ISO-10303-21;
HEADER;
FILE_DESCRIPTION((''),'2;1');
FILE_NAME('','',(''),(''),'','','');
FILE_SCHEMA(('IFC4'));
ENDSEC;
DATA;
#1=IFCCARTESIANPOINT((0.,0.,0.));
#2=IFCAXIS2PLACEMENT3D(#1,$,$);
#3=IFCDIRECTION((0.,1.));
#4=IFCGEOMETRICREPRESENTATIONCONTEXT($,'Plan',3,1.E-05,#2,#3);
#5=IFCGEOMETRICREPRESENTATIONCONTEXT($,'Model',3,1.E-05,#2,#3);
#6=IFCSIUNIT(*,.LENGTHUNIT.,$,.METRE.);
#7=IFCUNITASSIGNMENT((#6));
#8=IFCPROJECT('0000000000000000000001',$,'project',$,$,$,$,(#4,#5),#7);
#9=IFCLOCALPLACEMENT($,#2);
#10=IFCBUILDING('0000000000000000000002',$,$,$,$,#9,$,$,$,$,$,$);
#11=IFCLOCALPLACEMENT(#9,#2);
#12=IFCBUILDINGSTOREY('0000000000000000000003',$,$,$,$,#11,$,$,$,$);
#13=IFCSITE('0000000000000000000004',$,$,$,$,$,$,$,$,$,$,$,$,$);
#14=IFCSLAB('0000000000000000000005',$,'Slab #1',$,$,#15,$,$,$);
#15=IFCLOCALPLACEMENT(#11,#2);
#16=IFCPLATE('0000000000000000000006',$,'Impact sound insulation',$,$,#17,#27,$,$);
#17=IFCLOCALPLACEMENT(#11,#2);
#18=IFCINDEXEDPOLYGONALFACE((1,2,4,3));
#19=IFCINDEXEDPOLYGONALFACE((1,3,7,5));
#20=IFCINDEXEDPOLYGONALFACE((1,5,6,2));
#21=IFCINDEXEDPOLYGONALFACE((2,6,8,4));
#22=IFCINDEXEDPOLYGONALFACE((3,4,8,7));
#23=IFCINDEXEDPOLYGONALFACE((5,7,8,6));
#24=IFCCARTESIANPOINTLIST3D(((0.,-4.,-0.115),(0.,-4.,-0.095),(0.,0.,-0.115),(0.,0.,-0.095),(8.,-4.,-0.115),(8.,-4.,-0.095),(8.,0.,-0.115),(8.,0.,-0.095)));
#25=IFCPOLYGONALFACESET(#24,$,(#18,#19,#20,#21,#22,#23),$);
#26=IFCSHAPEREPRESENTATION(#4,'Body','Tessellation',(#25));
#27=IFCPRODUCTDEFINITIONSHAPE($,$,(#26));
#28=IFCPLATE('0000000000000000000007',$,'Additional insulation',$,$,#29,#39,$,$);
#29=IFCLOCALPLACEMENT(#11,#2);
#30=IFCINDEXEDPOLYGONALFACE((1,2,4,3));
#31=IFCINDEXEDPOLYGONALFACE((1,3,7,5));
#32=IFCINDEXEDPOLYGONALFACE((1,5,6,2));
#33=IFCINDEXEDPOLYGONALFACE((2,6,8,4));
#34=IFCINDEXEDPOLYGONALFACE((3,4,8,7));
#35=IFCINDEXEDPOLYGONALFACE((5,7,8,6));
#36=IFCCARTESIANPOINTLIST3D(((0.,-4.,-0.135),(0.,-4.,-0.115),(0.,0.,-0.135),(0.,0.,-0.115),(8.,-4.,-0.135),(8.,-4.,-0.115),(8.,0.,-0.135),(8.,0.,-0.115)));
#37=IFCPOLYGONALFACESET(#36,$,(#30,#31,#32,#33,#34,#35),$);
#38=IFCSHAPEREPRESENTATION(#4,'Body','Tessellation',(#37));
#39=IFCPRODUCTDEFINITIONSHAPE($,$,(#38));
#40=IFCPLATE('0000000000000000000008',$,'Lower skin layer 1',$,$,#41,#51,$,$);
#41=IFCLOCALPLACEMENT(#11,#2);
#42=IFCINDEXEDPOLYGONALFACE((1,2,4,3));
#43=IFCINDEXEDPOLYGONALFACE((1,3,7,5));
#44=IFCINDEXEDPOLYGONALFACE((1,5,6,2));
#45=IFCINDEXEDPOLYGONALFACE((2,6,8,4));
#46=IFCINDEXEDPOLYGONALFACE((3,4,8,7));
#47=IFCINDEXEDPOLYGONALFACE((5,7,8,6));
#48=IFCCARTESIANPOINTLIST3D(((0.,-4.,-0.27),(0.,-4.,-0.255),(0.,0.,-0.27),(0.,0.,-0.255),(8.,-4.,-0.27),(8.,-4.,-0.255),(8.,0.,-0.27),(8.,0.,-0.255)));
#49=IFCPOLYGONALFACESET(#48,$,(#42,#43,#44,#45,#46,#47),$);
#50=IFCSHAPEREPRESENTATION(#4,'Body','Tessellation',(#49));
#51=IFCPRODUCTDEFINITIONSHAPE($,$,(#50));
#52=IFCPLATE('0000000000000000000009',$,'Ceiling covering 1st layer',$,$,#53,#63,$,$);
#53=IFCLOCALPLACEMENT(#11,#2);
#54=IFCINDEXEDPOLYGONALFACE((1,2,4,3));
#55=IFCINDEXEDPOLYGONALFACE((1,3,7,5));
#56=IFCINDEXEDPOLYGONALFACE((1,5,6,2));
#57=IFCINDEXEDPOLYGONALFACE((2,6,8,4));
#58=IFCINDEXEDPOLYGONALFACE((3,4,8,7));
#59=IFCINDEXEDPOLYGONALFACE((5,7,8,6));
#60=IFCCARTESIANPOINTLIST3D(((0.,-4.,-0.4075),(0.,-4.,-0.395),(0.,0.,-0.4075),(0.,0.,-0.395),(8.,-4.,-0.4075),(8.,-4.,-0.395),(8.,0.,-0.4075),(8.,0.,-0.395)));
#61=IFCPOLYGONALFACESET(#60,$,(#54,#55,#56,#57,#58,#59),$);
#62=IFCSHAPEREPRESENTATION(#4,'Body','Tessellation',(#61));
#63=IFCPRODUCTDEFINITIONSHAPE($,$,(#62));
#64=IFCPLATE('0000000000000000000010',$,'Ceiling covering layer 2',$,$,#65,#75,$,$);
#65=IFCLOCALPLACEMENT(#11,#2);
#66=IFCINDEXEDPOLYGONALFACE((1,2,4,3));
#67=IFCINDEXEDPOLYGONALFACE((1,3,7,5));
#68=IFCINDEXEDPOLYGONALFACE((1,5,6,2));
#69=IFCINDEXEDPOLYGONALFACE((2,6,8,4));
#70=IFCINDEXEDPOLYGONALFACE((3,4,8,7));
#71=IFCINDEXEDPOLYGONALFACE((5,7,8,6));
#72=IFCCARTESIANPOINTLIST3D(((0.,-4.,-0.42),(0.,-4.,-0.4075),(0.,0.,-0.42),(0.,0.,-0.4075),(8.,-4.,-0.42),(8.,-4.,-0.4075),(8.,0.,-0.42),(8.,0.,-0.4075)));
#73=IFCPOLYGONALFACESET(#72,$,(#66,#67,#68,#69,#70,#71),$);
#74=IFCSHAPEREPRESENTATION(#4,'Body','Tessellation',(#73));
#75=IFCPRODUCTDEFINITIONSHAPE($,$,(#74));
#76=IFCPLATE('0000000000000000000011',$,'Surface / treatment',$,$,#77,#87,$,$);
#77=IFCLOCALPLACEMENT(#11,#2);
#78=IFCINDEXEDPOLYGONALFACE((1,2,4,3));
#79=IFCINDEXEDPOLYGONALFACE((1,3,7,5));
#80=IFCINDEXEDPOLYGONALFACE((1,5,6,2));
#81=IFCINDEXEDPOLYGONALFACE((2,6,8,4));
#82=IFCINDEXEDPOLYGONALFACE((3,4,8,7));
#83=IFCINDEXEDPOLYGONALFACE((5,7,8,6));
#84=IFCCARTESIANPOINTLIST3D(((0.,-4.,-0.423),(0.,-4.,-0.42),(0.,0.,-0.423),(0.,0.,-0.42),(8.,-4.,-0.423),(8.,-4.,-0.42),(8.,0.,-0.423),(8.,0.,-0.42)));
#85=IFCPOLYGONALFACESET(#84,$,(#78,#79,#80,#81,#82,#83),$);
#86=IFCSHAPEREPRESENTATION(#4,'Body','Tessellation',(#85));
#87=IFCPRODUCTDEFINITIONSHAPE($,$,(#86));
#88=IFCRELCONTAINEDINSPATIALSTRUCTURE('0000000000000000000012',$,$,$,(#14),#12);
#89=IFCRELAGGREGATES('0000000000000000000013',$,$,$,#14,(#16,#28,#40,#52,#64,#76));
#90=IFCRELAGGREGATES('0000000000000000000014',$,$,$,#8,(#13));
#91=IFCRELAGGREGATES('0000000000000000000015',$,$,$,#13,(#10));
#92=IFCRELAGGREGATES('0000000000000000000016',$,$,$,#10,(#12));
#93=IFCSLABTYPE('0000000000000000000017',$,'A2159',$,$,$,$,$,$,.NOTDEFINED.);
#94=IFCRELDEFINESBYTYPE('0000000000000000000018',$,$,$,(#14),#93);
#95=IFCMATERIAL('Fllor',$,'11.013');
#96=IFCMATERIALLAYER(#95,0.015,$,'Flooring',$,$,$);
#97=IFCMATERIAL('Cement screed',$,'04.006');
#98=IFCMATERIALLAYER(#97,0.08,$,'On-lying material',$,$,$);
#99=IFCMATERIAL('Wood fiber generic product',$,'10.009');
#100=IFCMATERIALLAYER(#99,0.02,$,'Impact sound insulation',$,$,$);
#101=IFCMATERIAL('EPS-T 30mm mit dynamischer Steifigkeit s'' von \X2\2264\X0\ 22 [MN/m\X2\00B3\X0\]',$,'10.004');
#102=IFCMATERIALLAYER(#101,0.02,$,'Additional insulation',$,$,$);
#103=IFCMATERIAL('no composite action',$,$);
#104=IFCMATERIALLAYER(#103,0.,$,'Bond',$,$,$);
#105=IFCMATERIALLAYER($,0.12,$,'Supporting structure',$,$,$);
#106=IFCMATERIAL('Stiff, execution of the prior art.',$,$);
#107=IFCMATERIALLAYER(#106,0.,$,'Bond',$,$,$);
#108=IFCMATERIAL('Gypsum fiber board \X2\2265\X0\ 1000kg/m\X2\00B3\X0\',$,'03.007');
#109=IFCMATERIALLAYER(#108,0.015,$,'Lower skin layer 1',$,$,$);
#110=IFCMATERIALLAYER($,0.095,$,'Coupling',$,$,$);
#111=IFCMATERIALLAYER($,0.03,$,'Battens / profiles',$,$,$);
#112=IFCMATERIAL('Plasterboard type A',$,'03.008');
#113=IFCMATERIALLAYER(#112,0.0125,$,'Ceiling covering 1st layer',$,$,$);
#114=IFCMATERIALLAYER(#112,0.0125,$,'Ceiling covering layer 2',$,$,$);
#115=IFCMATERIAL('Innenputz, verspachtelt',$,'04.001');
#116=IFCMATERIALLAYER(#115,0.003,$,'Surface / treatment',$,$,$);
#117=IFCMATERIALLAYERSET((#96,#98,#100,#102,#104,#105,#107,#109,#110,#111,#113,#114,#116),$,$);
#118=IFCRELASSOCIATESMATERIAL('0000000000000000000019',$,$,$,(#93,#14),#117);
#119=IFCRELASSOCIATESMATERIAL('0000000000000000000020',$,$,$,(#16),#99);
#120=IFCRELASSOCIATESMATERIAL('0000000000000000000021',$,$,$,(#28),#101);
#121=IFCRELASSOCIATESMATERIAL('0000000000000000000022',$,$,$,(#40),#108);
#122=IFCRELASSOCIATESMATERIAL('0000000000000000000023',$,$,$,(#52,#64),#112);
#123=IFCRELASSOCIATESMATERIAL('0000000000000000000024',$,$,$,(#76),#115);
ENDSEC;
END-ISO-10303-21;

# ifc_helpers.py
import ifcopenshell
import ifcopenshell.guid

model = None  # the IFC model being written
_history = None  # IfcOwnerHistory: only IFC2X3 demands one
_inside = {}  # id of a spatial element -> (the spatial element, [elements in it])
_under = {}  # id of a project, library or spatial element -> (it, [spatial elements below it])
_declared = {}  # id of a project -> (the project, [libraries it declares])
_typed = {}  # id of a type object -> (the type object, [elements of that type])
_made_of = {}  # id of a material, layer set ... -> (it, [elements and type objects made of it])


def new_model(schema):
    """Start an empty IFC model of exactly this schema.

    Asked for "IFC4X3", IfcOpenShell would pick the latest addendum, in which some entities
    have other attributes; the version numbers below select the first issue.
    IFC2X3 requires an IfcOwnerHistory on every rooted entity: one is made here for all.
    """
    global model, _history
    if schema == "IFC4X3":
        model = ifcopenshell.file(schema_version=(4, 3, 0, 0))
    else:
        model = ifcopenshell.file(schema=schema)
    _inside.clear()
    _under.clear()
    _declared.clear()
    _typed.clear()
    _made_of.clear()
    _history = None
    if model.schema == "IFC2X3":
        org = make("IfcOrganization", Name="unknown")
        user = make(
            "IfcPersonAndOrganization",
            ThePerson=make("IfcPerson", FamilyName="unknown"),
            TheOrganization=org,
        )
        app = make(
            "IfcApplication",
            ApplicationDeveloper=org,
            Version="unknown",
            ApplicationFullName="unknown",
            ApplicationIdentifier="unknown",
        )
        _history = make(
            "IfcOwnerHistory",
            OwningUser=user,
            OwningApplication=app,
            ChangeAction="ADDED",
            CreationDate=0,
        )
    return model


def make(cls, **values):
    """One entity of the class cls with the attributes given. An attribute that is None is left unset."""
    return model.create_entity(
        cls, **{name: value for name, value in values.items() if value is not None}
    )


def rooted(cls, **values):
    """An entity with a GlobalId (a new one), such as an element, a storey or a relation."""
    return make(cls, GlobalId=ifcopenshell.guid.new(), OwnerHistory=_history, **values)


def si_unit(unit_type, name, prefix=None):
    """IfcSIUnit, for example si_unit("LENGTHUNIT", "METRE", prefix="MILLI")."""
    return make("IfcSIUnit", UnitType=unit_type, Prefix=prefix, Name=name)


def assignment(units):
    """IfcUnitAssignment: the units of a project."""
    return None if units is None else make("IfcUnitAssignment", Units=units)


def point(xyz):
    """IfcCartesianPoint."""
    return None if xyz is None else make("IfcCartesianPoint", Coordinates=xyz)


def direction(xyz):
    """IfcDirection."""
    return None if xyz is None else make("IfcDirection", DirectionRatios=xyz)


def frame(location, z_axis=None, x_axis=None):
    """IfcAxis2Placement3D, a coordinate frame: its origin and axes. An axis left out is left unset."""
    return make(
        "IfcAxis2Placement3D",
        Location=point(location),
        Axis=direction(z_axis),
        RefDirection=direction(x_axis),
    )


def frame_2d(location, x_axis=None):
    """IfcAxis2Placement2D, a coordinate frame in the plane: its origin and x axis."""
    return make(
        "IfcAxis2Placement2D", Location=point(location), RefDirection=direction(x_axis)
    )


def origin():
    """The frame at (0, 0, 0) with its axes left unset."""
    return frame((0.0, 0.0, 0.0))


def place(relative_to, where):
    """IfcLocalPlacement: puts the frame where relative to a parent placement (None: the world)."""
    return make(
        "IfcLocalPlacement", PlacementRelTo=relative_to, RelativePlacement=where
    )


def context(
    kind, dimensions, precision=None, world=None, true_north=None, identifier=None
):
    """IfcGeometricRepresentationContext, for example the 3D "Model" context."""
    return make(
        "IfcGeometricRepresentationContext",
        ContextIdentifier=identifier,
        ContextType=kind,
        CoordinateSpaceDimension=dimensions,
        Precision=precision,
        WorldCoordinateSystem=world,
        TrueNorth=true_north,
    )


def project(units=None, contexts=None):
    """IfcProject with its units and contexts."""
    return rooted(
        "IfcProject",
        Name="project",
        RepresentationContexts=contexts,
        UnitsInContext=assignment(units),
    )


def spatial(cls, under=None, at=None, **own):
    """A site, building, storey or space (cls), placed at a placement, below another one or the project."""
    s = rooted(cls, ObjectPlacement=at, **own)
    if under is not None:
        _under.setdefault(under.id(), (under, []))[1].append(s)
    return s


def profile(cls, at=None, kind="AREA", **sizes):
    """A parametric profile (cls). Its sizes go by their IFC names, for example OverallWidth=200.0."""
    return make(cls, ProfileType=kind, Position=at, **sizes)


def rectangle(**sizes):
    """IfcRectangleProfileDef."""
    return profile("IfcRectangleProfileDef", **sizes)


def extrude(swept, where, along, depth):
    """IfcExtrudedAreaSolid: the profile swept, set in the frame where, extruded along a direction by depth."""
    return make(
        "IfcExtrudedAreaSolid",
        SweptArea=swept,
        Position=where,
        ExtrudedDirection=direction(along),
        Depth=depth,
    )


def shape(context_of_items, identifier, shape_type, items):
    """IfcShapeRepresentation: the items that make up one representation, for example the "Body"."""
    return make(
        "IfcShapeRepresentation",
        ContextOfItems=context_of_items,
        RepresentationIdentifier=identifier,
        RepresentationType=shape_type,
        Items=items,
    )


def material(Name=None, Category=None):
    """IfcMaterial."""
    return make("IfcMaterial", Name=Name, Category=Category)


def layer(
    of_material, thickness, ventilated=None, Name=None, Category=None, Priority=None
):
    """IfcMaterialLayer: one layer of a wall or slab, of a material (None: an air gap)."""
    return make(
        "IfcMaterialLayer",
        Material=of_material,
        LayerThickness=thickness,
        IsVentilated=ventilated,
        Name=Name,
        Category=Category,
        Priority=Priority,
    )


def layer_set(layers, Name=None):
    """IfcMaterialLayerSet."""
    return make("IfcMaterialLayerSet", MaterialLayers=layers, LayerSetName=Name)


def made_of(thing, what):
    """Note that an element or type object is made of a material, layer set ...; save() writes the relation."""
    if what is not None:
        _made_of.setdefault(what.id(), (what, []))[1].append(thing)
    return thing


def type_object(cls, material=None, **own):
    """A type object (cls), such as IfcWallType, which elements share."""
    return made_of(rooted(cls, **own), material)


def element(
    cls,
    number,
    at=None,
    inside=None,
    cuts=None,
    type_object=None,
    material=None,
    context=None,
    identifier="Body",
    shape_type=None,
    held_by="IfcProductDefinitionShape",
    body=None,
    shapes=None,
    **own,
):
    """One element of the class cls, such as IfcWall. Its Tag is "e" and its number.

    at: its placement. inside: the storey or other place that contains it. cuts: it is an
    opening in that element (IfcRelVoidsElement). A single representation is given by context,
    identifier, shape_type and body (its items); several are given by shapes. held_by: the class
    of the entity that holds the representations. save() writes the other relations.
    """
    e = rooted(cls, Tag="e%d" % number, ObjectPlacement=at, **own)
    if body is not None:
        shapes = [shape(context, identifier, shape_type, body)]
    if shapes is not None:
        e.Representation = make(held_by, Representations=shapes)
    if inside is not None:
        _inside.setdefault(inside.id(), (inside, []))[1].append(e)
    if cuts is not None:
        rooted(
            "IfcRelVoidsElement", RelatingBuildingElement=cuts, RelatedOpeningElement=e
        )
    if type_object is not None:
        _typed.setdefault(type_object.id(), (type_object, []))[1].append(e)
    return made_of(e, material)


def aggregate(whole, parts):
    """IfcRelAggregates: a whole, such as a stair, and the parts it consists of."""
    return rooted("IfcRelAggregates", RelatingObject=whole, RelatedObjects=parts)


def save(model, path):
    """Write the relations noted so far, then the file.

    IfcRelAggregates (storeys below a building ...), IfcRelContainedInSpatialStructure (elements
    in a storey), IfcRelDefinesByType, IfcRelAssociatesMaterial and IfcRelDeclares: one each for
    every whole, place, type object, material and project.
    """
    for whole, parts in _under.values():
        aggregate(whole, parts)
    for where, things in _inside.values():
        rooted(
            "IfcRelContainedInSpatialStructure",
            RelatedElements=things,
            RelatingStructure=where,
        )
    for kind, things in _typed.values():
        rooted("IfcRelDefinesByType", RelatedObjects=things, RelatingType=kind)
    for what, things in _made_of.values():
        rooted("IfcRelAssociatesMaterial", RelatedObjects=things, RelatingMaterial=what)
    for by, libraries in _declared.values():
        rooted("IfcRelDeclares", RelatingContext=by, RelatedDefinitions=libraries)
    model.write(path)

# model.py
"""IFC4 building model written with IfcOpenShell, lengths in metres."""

from ifc_helpers import new_model, si_unit, direction, frame, frame_2d, origin, place, context, project, spatial, rectangle, extrude, material, layer, layer_set, type_object, element, aggregate, save


model = new_model("IFC4")

# Units and contexts
plan_context = context("Plan", 3, precision=1e-05, world=origin(), true_north=direction((0.0, 1.0)))
model_context = context("Model", 3, precision=1e-05, world=origin(), true_north=direction((0.0, 1.0)))
ifc_project = project(units=[si_unit("LENGTHUNIT", "METRE")], contexts=[plan_context, model_context])

# Site, building, storey
site = spatial("IfcSite", under=ifc_project)
building_placement = place(None, origin())
building = spatial("IfcBuilding", under=site, at=building_placement)
storey_placement = place(building_placement, origin())
storey = spatial("IfcBuildingStorey", under=building, at=storey_placement)

# Slab, plates
ifc_material_1 = material(Name="Fllor", Category="11.013")
ifc_layer_1 = layer(ifc_material_1, 0.015, Name="Flooring")
ifc_material_2 = material(Name="Cement screed", Category="04.006")
ifc_layer_2 = layer(ifc_material_2, 0.08, Name="On-lying material")
ifc_material_3 = material(Name="Wood fiber generic product", Category="10.009")
ifc_layer_3 = layer(ifc_material_3, 0.02, Name="Impact sound insulation")
ifc_material_4 = material(Name="EPS-T 30mm mit dynamischer Steifigkeit s' von ≤ 22 [MN/m³]", Category="10.004")
ifc_layer_4 = layer(ifc_material_4, 0.02, Name="Additional insulation")
ifc_material_5 = material(Name="no composite action")
ifc_layer_5 = layer(ifc_material_5, 0.0, Name="Bond")
ifc_layer_6 = layer(None, 0.12, Name="Supporting structure")
ifc_material_6 = material(Name="Stiff, execution of the prior art.")
ifc_layer_7 = layer(ifc_material_6, 0.0, Name="Bond")
ifc_material_7 = material(Name="Gypsum fiber board ≥ 1000kg/m³", Category="03.007")
ifc_layer_8 = layer(ifc_material_7, 0.015, Name="Lower skin layer 1")
ifc_layer_9 = layer(None, 0.095, Name="Coupling")
ifc_layer_10 = layer(None, 0.03, Name="Battens / profiles")
ifc_material_8 = material(Name="Plasterboard type A", Category="03.008")
ifc_layer_11 = layer(ifc_material_8, 0.0125, Name="Ceiling covering 1st layer")
ifc_layer_12 = layer(ifc_material_8, 0.0125, Name="Ceiling covering layer 2")
ifc_material_9 = material(Name="Innenputz, verspachtelt", Category="04.001")
ifc_layer_13 = layer(ifc_material_9, 0.003, Name="Surface / treatment")
ifc_layer_set = layer_set([ifc_layer_1, ifc_layer_2, ifc_layer_3, ifc_layer_4, ifc_layer_5, ifc_layer_6, ifc_layer_7, ifc_layer_8, ifc_layer_9, ifc_layer_10, ifc_layer_11, ifc_layer_12, ifc_layer_13])
slab_type = type_object("IfcSlabType", Name="A2159", PredefinedType="NOTDEFINED", material=ifc_layer_set)
slab_placement = place(None, frame((0.0, 0.0, 0.0), z_axis=(0.0, 0.0, -1.0), x_axis=(1.0, 0.0, 0.0)))
slab = element("IfcSlab", 1, at=slab_placement, inside=storey, type_object=slab_type, material=ifc_layer_set, Name="Slab #1")
plate_1_placement = place(slab_placement, origin())
plate_1 = element("IfcPlate", 2, at=plate_1_placement, material=ifc_material_3, Name="Impact sound insulation", context=plan_context, shape_type="SweptSolid", body=[
    extrude(rectangle(XDim=8.0, YDim=4.0, at=frame_2d((4.0, 2.0), x_axis=(1.0, 0.0))), frame((0.0, 0.0, 0.095), z_axis=(0.0, 0.0, 1.0), x_axis=(1.0, 0.0, 0.0)), (0.0, 0.0, 1.0), 0.02),
])
plate_2_placement = place(slab_placement, origin())
plate_2 = element("IfcPlate", 3, at=plate_2_placement, material=ifc_material_4, Name="Additional insulation", context=plan_context, shape_type="SweptSolid", body=[
    extrude(rectangle(XDim=8.0, YDim=4.0, at=frame_2d((4.0, 2.0), x_axis=(1.0, 0.0))), frame((0.0, 0.0, 0.115), z_axis=(0.0, 0.0, 1.0), x_axis=(1.0, 0.0, 0.0)), (0.0, 0.0, 1.0), 0.02),
])
plate_3_placement = place(slab_placement, origin())
plate_3 = element("IfcPlate", 4, at=plate_3_placement, material=ifc_material_7, Name="Lower skin layer 1", context=plan_context, shape_type="SweptSolid", body=[
    extrude(rectangle(XDim=8.0, YDim=4.0, at=frame_2d((4.0, 2.0), x_axis=(1.0, 0.0))), frame((0.0, 0.0, 0.255), z_axis=(0.0, 0.0, 1.0), x_axis=(1.0, 0.0, 0.0)), (0.0, 0.0, 1.0), 0.015),
])
plate_4_placement = place(slab_placement, origin())
plate_4 = element("IfcPlate", 5, at=plate_4_placement, material=ifc_material_8, Name="Ceiling covering 1st layer", context=plan_context, shape_type="SweptSolid", body=[
    extrude(rectangle(XDim=8.0, YDim=4.0, at=frame_2d((4.0, 2.0), x_axis=(1.0, 0.0))), frame((0.0, 0.0, 0.395), z_axis=(0.0, 0.0, 1.0), x_axis=(1.0, 0.0, 0.0)), (0.0, 0.0, 1.0), 0.0125),
])
plate_5_placement = place(slab_placement, origin())
plate_5 = element("IfcPlate", 6, at=plate_5_placement, material=ifc_material_8, Name="Ceiling covering layer 2", context=plan_context, shape_type="SweptSolid", body=[
    extrude(rectangle(XDim=8.0, YDim=4.0, at=frame_2d((4.0, 2.0), x_axis=(1.0, 0.0))), frame((0.0, 0.0, 0.4075), z_axis=(0.0, 0.0, 1.0), x_axis=(1.0, 0.0, 0.0)), (0.0, 0.0, 1.0), 0.0125),
])
plate_6_placement = place(slab_placement, origin())
plate_6 = element("IfcPlate", 7, at=plate_6_placement, material=ifc_material_9, Name="Surface / treatment", context=plan_context, shape_type="SweptSolid", body=[
    extrude(rectangle(XDim=8.0, YDim=4.0, at=frame_2d((4.0, 2.0), x_axis=(1.0, 0.0))), frame((0.0, 0.0, 0.42), z_axis=(0.0, 0.0, 1.0), x_axis=(1.0, 0.0, 0.0)), (0.0, 0.0, 1.0), 0.003),
])
aggregate(slab, [plate_1, plate_2, plate_3, plate_4, plate_5, plate_6])

save(model, "model.ifc")
